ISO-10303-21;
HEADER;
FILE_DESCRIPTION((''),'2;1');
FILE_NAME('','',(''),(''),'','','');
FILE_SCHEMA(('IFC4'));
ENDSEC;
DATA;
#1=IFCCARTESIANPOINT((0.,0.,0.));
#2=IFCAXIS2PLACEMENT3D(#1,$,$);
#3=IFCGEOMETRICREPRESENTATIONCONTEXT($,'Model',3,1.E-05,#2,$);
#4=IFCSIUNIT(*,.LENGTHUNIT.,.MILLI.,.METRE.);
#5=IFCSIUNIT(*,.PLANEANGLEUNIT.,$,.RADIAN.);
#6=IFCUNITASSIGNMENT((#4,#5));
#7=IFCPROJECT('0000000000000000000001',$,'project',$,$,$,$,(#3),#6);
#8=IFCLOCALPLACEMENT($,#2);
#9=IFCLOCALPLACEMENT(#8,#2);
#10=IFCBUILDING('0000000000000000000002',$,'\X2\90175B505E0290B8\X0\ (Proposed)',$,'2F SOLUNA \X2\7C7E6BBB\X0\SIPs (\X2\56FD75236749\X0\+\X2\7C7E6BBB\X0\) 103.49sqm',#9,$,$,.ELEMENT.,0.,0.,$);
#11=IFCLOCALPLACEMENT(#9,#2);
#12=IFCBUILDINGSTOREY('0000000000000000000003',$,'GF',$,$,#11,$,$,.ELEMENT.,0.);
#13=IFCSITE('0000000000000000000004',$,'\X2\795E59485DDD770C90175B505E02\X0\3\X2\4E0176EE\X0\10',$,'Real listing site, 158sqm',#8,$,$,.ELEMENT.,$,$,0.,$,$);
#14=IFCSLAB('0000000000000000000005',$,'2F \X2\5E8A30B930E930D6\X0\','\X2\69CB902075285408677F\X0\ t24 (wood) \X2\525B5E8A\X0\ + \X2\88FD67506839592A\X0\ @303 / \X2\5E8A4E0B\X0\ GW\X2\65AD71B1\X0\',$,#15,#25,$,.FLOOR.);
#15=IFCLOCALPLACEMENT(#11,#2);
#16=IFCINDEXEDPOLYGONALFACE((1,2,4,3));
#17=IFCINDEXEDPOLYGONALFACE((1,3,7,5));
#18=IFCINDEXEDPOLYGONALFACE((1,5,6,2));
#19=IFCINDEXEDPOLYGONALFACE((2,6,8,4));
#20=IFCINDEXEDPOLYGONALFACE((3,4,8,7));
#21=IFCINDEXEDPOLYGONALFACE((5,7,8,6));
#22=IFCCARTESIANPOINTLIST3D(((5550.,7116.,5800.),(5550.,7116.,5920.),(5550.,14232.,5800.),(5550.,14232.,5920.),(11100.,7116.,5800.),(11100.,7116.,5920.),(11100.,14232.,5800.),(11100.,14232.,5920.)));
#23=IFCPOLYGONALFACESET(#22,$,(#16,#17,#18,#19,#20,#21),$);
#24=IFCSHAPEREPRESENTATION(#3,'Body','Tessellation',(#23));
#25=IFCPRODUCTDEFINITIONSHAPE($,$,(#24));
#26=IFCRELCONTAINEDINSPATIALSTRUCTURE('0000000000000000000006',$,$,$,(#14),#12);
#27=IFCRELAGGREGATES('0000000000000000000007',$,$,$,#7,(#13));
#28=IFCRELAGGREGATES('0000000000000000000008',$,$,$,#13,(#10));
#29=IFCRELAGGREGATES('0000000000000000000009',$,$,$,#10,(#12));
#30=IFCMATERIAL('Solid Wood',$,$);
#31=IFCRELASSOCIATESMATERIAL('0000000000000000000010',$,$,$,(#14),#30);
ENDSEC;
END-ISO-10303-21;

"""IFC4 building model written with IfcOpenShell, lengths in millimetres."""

from ifc_helpers import new_model, si_unit, frame, frame_2d, origin, place, context, project, spatial, rectangle, extrude, material, element, save


model = new_model("IFC4")

# Units and contexts
model_context = context("Model", 3, precision=1e-05, world=origin())
ifc_project = project(units=[si_unit("LENGTHUNIT", "METRE", prefix="MILLI"), si_unit("PLANEANGLEUNIT", "RADIAN")], contexts=[model_context])

# Site, building, storey
site_placement = place(None, origin())
site = spatial("IfcSite", under=ifc_project, at=site_placement, Name="神奈川県逗子市3丁目10", ObjectType="Real listing site, 158sqm", CompositionType="ELEMENT", RefElevation=0.0)
building_placement = place(site_placement, origin())
building = spatial("IfcBuilding", under=site, at=building_placement, Name="逗子市邸 (Proposed)", ObjectType="2F SOLUNA 籾殻SIPs (国産杉+籾殻) 103.49sqm", CompositionType="ELEMENT", ElevationOfRefHeight=0.0, ElevationOfTerrain=0.0)
storey_placement = place(building_placement, origin())
storey = spatial("IfcBuildingStorey", under=building, at=storey_placement, Name="GF", CompositionType="ELEMENT", Elevation=0.0)

# Slab
ifc_material_1 = material(Name="Solid Wood")
slab_placement = place(storey_placement, frame((2775.0, 3558.0, 2900.0)))
element("IfcSlab", 1, at=slab_placement, inside=storey, material=ifc_material_1, Name="2F 床スラブ", Description="構造用合板 t24 (wood) 剛床 + 製材根太 @303 / 床下 GW断熱", PredefinedType="FLOOR", context=model_context, shape_type="SweptSolid", body=[
    extrude(rectangle(XDim=5550.0, YDim=7116.0, at=frame_2d((2775.0, 3558.0))), frame((2775.0, 3558.0, 2900.0)), (0.0, 0.0, 1.0), 120.0),
])

save(model, "model.ifc")
